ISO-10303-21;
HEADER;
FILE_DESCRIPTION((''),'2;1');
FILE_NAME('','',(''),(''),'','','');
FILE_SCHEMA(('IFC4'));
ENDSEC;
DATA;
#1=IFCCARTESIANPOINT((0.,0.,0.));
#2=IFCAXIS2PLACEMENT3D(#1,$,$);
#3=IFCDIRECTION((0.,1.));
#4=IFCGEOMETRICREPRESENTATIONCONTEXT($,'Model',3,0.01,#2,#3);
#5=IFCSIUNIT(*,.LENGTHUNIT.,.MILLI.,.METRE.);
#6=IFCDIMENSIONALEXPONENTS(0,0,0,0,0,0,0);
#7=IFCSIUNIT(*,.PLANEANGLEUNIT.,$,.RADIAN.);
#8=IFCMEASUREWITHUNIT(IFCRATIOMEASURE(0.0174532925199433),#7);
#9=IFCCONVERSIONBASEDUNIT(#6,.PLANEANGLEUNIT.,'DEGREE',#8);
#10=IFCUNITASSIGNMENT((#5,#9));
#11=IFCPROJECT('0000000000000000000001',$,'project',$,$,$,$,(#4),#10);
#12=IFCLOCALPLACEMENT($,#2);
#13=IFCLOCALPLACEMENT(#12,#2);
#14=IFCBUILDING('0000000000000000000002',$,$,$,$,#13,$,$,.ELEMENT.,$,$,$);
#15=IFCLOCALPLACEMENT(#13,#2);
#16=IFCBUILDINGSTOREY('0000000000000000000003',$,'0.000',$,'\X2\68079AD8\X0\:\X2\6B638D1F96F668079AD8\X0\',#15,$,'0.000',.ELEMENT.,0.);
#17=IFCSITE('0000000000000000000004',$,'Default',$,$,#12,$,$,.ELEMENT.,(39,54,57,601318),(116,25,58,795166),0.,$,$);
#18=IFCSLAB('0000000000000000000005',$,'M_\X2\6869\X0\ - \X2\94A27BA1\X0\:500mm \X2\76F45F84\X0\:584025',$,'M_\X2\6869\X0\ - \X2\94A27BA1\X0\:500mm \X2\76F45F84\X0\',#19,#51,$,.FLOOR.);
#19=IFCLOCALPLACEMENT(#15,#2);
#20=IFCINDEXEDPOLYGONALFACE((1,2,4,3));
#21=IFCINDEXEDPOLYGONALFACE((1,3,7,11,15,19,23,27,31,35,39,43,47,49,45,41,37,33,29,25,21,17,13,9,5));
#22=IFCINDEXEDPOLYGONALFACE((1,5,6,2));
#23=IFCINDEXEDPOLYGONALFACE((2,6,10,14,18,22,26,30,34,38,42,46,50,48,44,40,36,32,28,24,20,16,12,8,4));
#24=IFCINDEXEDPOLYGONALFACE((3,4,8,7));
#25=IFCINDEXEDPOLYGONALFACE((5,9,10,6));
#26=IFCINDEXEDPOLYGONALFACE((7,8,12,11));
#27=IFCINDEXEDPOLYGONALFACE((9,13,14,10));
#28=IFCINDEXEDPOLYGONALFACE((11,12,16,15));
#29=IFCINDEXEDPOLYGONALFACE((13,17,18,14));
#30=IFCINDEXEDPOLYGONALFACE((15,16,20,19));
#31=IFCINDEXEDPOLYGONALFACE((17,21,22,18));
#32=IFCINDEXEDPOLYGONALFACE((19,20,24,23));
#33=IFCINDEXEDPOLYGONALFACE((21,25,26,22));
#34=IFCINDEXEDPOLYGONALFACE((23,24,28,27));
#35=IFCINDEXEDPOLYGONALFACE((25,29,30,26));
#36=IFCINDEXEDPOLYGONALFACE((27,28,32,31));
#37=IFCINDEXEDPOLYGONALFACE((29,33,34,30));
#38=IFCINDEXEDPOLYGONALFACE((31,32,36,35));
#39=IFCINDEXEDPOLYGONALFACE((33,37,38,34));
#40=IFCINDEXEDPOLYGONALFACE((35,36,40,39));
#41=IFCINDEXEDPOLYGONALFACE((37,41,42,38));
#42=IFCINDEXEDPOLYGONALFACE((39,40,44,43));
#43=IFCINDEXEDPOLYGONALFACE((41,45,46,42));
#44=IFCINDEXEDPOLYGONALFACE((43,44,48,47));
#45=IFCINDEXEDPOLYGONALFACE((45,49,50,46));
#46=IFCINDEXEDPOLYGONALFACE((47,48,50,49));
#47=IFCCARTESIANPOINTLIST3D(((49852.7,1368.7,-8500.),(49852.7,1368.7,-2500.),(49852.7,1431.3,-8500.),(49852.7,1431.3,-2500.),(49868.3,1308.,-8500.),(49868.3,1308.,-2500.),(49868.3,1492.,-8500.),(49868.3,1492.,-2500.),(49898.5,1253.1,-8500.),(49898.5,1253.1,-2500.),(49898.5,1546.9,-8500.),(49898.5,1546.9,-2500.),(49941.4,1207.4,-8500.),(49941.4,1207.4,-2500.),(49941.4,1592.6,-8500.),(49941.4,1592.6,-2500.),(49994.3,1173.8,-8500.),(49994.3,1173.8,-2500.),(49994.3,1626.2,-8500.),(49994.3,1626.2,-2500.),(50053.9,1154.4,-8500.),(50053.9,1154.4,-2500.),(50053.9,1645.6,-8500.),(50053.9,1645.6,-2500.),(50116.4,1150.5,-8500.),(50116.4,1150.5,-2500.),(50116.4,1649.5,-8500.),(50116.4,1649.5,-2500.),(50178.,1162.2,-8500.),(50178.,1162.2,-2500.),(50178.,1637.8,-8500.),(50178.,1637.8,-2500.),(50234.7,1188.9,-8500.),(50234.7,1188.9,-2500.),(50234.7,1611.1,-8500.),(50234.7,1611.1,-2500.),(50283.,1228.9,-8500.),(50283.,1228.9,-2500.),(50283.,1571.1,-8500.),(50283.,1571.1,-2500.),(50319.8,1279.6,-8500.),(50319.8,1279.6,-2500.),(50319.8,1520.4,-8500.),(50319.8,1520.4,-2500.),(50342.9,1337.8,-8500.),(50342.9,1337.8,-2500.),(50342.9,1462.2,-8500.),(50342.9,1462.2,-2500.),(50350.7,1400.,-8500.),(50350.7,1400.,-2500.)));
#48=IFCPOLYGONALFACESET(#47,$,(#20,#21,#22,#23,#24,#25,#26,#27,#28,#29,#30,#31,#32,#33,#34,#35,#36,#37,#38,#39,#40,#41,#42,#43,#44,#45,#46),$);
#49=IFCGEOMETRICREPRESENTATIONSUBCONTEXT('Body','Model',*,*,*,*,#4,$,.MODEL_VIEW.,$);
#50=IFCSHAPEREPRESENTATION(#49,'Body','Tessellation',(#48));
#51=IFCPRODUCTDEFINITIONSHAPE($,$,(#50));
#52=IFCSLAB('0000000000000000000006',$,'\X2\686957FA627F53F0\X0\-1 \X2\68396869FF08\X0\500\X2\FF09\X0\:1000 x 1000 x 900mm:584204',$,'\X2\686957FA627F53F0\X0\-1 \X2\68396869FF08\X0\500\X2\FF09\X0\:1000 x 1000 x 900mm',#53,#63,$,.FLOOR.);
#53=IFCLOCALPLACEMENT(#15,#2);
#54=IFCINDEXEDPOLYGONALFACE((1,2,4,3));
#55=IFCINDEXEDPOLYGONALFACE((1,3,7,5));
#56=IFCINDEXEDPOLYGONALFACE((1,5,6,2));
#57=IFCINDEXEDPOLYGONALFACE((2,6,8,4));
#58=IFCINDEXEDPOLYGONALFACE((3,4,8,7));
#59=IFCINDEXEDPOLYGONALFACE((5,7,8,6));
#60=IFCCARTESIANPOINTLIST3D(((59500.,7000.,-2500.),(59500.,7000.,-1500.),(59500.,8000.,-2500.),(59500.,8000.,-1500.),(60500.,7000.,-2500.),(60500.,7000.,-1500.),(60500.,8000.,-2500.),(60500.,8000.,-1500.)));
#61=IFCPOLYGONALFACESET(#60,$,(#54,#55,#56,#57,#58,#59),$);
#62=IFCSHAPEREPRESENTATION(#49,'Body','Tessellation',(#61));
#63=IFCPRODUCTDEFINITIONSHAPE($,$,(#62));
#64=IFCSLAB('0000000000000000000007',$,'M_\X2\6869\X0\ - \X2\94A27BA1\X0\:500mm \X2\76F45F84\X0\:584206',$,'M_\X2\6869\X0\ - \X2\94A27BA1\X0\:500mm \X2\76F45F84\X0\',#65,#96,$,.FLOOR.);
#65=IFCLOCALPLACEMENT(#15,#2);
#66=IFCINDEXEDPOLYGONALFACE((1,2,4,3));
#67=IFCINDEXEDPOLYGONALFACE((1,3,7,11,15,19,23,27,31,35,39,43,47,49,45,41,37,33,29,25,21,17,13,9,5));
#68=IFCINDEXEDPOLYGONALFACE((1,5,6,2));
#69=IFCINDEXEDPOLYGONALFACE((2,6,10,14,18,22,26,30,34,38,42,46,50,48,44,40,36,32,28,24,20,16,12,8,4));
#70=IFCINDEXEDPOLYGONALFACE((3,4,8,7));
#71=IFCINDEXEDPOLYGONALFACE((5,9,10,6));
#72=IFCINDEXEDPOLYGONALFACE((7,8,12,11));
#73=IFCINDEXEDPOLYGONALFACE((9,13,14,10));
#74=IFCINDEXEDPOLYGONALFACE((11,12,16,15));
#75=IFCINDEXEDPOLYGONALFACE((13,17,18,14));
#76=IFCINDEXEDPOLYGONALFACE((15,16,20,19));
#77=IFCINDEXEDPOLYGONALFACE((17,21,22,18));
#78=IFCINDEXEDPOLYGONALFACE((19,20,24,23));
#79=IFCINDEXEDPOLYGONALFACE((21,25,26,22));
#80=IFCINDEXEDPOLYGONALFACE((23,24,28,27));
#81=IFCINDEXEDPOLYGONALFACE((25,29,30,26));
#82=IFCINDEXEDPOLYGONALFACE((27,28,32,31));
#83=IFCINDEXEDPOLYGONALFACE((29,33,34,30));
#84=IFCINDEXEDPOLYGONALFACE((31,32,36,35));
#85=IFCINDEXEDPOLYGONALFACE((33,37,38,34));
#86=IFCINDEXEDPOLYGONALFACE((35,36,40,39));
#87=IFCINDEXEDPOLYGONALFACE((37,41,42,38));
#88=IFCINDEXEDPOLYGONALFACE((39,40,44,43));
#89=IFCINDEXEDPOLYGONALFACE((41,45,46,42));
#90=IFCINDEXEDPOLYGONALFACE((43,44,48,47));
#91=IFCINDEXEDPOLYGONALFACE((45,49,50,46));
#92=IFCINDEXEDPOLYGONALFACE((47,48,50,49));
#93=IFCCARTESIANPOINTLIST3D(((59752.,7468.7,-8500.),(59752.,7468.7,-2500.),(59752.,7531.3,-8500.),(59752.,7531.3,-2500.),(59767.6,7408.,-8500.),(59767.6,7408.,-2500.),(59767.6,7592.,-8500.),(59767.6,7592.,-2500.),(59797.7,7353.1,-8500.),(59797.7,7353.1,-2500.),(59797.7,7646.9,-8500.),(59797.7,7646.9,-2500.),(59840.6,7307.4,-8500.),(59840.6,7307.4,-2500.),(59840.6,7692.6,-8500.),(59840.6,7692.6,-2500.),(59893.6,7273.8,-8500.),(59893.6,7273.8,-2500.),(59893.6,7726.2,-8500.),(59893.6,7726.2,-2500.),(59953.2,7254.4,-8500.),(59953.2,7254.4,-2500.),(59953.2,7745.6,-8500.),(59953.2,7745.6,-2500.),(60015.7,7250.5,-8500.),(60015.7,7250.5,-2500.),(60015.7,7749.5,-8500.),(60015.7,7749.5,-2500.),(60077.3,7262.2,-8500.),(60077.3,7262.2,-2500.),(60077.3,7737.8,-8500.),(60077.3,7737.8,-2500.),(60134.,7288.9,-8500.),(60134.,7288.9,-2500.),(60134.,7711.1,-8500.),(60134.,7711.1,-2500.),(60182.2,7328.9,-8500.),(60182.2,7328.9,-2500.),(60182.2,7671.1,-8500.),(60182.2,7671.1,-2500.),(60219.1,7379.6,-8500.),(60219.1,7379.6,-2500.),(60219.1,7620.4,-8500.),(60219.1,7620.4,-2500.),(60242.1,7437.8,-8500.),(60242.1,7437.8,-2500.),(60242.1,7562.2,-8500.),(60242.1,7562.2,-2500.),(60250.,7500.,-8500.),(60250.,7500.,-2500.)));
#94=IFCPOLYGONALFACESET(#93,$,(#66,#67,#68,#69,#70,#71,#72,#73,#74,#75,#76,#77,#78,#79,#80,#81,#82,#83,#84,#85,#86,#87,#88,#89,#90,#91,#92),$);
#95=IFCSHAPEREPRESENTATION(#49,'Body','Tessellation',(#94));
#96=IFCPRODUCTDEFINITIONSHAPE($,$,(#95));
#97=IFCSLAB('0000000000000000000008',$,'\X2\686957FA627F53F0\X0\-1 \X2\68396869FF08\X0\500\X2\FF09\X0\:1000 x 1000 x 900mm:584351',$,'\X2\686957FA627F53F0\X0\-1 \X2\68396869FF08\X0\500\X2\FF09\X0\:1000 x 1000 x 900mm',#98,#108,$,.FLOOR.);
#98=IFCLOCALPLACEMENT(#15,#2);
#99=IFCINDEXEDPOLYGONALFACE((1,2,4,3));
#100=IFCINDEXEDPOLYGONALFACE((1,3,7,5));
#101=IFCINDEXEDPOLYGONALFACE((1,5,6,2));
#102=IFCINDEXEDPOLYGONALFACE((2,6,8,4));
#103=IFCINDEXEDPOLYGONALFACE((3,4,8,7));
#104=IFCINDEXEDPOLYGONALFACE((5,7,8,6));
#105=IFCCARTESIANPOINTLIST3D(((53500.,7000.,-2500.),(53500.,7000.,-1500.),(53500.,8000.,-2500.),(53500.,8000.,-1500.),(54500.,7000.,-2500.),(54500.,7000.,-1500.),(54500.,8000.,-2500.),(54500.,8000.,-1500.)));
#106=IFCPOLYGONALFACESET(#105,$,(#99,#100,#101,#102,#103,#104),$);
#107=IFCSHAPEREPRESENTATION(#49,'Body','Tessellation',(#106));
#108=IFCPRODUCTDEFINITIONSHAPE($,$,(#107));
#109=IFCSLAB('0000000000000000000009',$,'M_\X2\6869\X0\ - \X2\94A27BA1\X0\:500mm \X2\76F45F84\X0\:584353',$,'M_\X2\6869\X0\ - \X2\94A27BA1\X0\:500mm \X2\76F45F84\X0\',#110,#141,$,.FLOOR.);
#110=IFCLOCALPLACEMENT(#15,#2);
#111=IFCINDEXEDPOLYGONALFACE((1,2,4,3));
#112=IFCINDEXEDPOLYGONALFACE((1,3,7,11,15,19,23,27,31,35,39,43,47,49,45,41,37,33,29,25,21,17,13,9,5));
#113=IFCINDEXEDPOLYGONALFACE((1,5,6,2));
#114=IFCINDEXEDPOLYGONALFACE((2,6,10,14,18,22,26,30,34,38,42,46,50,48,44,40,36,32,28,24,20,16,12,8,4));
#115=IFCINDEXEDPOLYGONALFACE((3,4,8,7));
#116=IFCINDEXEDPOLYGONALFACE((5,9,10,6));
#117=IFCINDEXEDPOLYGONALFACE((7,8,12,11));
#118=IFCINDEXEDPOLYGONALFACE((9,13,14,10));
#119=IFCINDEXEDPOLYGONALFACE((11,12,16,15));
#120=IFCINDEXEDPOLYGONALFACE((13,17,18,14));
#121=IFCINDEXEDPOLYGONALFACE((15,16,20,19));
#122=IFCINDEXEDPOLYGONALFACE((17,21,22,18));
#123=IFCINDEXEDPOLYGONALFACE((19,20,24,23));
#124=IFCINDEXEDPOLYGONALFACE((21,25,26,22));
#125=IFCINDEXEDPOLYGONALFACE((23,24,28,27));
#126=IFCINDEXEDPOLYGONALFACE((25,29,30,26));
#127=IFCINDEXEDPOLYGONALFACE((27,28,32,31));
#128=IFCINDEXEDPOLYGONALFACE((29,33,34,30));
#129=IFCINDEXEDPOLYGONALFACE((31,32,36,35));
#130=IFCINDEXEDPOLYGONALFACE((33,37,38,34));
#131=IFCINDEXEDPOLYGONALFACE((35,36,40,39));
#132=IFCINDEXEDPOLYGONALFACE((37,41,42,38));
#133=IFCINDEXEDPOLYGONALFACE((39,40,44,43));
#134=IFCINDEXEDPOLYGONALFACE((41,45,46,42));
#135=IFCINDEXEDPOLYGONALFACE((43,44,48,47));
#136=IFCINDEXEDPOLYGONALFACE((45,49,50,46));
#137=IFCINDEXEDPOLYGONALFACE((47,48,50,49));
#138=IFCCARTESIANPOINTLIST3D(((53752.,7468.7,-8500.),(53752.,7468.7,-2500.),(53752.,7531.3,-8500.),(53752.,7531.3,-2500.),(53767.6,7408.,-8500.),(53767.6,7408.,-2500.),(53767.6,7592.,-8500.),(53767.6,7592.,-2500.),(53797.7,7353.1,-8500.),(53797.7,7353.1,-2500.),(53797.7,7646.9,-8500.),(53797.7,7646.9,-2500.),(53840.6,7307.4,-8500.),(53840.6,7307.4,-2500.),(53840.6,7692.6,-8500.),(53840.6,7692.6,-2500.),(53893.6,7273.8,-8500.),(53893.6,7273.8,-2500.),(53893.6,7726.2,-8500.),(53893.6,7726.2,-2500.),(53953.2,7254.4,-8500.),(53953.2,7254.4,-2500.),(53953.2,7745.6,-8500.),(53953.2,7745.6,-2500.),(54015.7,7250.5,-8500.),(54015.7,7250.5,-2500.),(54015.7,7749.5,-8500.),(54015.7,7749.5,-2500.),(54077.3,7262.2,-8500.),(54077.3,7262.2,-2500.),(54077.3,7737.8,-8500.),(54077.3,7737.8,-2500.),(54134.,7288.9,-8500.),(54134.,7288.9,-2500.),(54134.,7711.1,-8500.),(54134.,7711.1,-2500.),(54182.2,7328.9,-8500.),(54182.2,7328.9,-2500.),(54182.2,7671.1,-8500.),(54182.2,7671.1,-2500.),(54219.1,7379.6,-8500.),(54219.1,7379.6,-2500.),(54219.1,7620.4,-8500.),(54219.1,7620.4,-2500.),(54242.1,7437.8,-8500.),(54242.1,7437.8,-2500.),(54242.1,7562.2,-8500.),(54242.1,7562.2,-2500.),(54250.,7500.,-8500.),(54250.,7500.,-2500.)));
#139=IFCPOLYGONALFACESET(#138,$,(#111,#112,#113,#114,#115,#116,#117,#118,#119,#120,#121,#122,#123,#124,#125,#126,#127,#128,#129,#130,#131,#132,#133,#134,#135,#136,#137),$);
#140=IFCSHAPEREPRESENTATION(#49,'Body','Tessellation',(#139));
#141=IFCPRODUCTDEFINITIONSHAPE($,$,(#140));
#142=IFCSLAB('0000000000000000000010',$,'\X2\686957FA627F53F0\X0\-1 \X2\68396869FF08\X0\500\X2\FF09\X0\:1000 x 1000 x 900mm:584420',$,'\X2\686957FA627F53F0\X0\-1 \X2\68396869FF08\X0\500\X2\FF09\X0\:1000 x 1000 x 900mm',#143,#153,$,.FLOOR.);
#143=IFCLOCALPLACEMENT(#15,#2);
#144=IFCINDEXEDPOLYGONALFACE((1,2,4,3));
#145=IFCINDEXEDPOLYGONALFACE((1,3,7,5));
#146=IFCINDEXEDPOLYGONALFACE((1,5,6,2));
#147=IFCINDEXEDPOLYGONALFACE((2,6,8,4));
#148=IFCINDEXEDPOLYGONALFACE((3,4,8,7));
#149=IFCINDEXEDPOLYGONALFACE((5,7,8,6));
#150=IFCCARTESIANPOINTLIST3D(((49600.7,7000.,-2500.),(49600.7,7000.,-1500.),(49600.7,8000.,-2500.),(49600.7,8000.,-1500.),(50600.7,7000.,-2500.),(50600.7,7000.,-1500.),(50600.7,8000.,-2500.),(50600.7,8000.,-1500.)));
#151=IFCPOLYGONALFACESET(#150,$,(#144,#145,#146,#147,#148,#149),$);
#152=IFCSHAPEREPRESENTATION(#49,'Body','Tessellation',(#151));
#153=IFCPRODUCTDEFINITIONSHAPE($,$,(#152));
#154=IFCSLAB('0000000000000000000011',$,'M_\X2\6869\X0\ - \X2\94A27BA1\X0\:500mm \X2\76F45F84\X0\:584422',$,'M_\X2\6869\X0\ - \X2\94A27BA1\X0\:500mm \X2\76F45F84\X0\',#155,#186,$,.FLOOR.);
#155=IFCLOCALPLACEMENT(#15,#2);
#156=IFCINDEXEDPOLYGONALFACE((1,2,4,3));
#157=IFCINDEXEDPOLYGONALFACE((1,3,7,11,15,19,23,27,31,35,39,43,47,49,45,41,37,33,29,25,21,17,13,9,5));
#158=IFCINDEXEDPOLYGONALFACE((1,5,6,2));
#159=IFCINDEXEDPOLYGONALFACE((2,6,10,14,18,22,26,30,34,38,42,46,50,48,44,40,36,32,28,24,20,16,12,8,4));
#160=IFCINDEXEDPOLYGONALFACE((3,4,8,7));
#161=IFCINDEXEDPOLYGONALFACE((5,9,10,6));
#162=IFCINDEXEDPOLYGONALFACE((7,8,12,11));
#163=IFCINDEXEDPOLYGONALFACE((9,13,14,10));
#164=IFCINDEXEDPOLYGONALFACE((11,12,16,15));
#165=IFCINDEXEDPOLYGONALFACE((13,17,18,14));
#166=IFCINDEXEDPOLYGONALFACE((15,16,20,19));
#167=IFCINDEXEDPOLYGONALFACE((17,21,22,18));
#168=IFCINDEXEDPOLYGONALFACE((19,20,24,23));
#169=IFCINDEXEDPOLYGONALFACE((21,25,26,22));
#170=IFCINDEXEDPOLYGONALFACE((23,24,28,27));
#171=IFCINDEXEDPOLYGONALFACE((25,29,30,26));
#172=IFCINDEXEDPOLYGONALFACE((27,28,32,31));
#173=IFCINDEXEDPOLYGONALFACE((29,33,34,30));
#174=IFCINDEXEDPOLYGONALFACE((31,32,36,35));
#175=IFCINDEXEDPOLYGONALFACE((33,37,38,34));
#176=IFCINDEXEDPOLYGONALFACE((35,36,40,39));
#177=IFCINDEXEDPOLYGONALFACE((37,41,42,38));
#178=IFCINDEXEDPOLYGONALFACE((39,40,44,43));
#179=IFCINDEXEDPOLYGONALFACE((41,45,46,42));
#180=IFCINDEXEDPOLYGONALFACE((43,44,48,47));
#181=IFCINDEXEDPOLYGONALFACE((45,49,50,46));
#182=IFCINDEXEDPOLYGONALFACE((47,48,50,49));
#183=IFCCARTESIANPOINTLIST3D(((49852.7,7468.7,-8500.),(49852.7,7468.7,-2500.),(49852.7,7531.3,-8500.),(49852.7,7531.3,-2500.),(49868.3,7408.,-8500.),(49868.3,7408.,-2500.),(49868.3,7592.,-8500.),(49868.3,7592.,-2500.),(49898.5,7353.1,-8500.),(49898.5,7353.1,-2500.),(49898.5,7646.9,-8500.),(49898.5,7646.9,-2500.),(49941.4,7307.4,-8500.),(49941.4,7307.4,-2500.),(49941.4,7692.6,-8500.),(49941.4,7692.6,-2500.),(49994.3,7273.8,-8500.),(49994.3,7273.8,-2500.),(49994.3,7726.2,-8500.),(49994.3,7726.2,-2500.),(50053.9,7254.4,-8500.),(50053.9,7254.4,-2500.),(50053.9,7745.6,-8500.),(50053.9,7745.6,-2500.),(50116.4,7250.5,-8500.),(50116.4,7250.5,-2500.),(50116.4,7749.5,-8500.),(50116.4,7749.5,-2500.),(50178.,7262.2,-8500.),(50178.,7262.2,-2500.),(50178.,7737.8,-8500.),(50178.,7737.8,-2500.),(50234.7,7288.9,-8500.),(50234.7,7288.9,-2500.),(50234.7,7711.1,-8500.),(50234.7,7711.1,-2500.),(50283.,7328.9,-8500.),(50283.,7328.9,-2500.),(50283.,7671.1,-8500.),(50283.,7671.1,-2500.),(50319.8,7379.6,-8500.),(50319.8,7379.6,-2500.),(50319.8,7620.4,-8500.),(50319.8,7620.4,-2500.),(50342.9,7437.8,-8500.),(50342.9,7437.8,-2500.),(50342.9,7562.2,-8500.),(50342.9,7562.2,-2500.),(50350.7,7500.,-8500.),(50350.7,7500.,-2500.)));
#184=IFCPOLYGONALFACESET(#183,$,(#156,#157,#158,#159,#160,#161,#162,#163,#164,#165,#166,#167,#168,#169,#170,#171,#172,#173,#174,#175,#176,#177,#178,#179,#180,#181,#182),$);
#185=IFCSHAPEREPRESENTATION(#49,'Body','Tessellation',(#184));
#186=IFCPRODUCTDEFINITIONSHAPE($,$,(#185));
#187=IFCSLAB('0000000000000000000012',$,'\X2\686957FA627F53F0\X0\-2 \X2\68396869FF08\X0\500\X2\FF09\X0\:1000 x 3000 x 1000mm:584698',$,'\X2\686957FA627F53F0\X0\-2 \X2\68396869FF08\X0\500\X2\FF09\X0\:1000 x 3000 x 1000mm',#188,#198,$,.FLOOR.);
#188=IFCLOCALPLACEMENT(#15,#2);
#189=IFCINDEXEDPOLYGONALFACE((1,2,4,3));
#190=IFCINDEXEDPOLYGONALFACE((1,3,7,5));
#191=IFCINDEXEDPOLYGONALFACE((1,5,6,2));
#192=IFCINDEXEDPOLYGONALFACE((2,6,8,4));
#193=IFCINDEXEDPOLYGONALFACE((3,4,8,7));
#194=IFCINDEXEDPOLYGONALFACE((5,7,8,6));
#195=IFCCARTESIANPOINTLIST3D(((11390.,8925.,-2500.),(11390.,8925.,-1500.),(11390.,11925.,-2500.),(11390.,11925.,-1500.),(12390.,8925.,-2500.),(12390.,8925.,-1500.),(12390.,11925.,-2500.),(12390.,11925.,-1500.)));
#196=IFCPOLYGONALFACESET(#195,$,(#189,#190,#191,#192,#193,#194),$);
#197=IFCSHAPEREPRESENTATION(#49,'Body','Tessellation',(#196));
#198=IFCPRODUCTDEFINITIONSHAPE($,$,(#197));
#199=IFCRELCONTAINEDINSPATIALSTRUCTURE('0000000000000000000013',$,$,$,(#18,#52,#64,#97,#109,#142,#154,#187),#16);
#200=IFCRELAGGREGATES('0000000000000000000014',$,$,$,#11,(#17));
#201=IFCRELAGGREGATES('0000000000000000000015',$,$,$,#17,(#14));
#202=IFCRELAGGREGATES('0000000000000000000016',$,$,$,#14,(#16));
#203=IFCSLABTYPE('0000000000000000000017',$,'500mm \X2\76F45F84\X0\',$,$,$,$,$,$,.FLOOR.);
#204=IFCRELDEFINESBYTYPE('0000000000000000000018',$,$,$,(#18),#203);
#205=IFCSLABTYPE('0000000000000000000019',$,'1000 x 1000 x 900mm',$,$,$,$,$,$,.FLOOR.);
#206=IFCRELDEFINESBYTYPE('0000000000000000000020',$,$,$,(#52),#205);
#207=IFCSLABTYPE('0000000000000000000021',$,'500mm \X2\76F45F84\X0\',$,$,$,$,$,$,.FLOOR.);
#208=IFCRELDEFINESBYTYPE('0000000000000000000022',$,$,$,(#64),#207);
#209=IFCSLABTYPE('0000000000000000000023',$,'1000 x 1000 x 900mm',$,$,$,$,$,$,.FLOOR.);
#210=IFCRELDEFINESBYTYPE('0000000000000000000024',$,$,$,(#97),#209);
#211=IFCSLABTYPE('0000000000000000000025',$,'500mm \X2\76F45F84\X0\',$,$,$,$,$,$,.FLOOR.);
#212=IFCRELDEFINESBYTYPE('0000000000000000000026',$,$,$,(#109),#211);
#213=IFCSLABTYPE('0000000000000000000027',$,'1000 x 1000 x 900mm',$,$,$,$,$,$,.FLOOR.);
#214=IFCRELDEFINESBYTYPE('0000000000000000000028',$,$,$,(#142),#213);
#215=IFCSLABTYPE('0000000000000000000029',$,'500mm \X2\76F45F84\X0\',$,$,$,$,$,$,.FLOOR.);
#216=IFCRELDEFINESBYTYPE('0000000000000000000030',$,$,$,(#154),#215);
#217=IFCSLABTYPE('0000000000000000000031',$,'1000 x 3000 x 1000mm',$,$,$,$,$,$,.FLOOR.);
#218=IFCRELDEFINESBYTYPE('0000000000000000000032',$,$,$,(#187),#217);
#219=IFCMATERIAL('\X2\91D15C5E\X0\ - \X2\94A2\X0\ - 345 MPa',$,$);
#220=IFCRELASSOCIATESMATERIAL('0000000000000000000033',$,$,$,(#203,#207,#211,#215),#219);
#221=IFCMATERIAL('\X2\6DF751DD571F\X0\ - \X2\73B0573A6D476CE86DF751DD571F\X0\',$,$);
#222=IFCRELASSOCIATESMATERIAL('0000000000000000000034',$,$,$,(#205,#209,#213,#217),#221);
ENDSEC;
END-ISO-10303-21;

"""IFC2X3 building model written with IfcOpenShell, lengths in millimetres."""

from ifc_helpers import new_model, entity, si_unit, converted_unit, direction, frame, frame_2d, origin, origin_2d_with_axis, place, context, subcontext, project, spatial, rectangle, circle, extrude, material, type_object, element, save


model = new_model("IFC2X3")

# Units and contexts
model_context = context("Model", 3, precision=0.01, world=origin(), true_north=direction((0.0, 1.0)))
body_context = subcontext(model_context, "Body", "Model", "MODEL_VIEW")
ifc_project = project(units=[si_unit("LENGTHUNIT", "METRE", prefix="MILLI"), converted_unit("PLANEANGLEUNIT", "DEGREE", entity("IfcRatioMeasure", 0.0174532925199433), si_unit("PLANEANGLEUNIT", "RADIAN"), dimensions=[0, 0, 0, 0, 0, 0, 0])], contexts=[model_context])

# Site, building, storey
site_placement = place(None, origin())
site = spatial("IfcSite", under=ifc_project, at=site_placement, Name="Default", CompositionType="ELEMENT", RefLatitude=(39, 54, 57, 601318), RefLongitude=(116, 25, 58, 795166), RefElevation=0.0)
building_placement = place(site_placement, origin())
building = spatial("IfcBuilding", under=site, at=building_placement, CompositionType="ELEMENT")
storey_placement = place(building_placement, origin())
storey = spatial("IfcBuildingStorey", under=building, at=storey_placement, Name="0.000", ObjectType="标高:正负零标高", LongName="0.000", CompositionType="ELEMENT", Elevation=0.0)

# Slabs
ifc_material_1 = material(Name="金属 - 钢 - 345 MPa")
ifc_material_2 = material(Name="混凝土 - 现场浇注混凝土")
slab_type_1 = type_object("IfcSlabType", Name="500mm 直径", PredefinedType="FLOOR", material=ifc_material_1)
slab_1_placement = place(storey_placement, origin())
element("IfcSlab", 1, at=slab_1_placement, inside=storey, type_object=slab_type_1, Name="M_桩 - 钢管:500mm 直径:584025", ObjectType="M_桩 - 钢管:500mm 直径", PredefinedType="FLOOR", context=body_context, shape_type="SweptSolid", body=[
    extrude(circle(Radius=250.0, at=frame_2d((0.0, 0.0), x_axis=(1.0, 0.0))), frame((50100.7, 1400.0, -8500.0)), (0.0, 0.0, 1.0), 6000.0),
])
slab_type_2 = type_object("IfcSlabType", Name="1000 x 1000 x 900mm", PredefinedType="FLOOR", material=ifc_material_2)
slab_2_placement = place(storey_placement, origin())
element("IfcSlab", 2, at=slab_2_placement, inside=storey, type_object=slab_type_2, Name="桩基承台-1 根桩（500）:1000 x 1000 x 900mm:584204", ObjectType="桩基承台-1 根桩（500）:1000 x 1000 x 900mm", PredefinedType="FLOOR", context=body_context, shape_type="SweptSolid", body=[
    extrude(rectangle(XDim=1000.0, YDim=1000.0, at=frame_2d((0.0, 0.0), x_axis=(1.0, 0.0))), frame((60000.0, 7500.0, -2500.0), z_axis=(0.0, 0.0, 1.0), x_axis=(-1.0, 0.0, 0.0)), (0.0, 0.0, 1.0), 1000.0),
])
slab_type_3 = type_object("IfcSlabType", Name="500mm 直径", PredefinedType="FLOOR", material=ifc_material_1)
slab_3_placement = place(storey_placement, origin())
element("IfcSlab", 3, at=slab_3_placement, inside=storey, type_object=slab_type_3, Name="M_桩 - 钢管:500mm 直径:584206", ObjectType="M_桩 - 钢管:500mm 直径", PredefinedType="FLOOR", context=body_context, shape_type="SweptSolid", body=[
    extrude(circle(Radius=250.0, at=origin_2d_with_axis()), frame((60000.0, 7500.0, -8500.0)), (0.0, 0.0, 1.0), 6000.0),
])
slab_type_4 = type_object("IfcSlabType", Name="1000 x 1000 x 900mm", PredefinedType="FLOOR", material=ifc_material_2)
slab_4_placement = place(storey_placement, origin())
element("IfcSlab", 4, at=slab_4_placement, inside=storey, type_object=slab_type_4, Name="桩基承台-1 根桩（500）:1000 x 1000 x 900mm:584351", ObjectType="桩基承台-1 根桩（500）:1000 x 1000 x 900mm", PredefinedType="FLOOR", context=body_context, shape_type="SweptSolid", body=[
    extrude(rectangle(XDim=1000.0, YDim=1000.0, at=frame_2d((0.0, 0.0), x_axis=(1.0, 0.0))), frame((54000.0, 7500.0, -2500.0), z_axis=(0.0, 0.0, 1.0), x_axis=(-1.0, 0.0, 0.0)), (0.0, 0.0, 1.0), 1000.0),
])
slab_type_5 = type_object("IfcSlabType", Name="500mm 直径", PredefinedType="FLOOR", material=ifc_material_1)
slab_5_placement = place(storey_placement, origin())
element("IfcSlab", 5, at=slab_5_placement, inside=storey, type_object=slab_type_5, Name="M_桩 - 钢管:500mm 直径:584353", ObjectType="M_桩 - 钢管:500mm 直径", PredefinedType="FLOOR", context=body_context, shape_type="SweptSolid", body=[
    extrude(circle(Radius=250.0, at=origin_2d_with_axis()), frame((54000.0, 7500.0, -8500.0)), (0.0, 0.0, 1.0), 6000.0),
])
slab_type_6 = type_object("IfcSlabType", Name="1000 x 1000 x 900mm", PredefinedType="FLOOR", material=ifc_material_2)
slab_6_placement = place(storey_placement, origin())
element("IfcSlab", 6, at=slab_6_placement, inside=storey, type_object=slab_type_6, Name="桩基承台-1 根桩（500）:1000 x 1000 x 900mm:584420", ObjectType="桩基承台-1 根桩（500）:1000 x 1000 x 900mm", PredefinedType="FLOOR", context=body_context, shape_type="SweptSolid", body=[
    extrude(rectangle(XDim=1000.0, YDim=1000.0, at=frame_2d((0.0, 0.0), x_axis=(1.0, 0.0))), frame((50100.7, 7500.0, -2500.0), z_axis=(0.0, 0.0, 1.0), x_axis=(-1.0, 0.0, 0.0)), (0.0, 0.0, 1.0), 1000.0),
])
slab_type_7 = type_object("IfcSlabType", Name="500mm 直径", PredefinedType="FLOOR", material=ifc_material_1)
slab_7_placement = place(storey_placement, origin())
element("IfcSlab", 7, at=slab_7_placement, inside=storey, type_object=slab_type_7, Name="M_桩 - 钢管:500mm 直径:584422", ObjectType="M_桩 - 钢管:500mm 直径", PredefinedType="FLOOR", context=body_context, shape_type="SweptSolid", body=[
    extrude(circle(Radius=250.0, at=origin_2d_with_axis()), frame((50100.7, 7500.0, -8500.0)), (0.0, 0.0, 1.0), 6000.0),
])
slab_type_8 = type_object("IfcSlabType", Name="1000 x 3000 x 1000mm", PredefinedType="FLOOR", material=ifc_material_2)
slab_8_placement = place(storey_placement, origin())
element("IfcSlab", 8, at=slab_8_placement, inside=storey, type_object=slab_type_8, Name="桩基承台-2 根桩（500）:1000 x 3000 x 1000mm:584698", ObjectType="桩基承台-2 根桩（500）:1000 x 3000 x 1000mm", PredefinedType="FLOOR", context=body_context, shape_type="SweptSolid", body=[
    extrude(rectangle(XDim=3000.0, YDim=1000.0, at=frame_2d((0.0, 0.0), x_axis=(1.0, 0.0))), frame((11890.0, 10425.0, -2500.0), z_axis=(0.0, 0.0, 1.0), x_axis=(0.0, -1.0, 0.0)), (0.0, 0.0, 1.0), 1000.0),
])

save(model, "model.ifc")
